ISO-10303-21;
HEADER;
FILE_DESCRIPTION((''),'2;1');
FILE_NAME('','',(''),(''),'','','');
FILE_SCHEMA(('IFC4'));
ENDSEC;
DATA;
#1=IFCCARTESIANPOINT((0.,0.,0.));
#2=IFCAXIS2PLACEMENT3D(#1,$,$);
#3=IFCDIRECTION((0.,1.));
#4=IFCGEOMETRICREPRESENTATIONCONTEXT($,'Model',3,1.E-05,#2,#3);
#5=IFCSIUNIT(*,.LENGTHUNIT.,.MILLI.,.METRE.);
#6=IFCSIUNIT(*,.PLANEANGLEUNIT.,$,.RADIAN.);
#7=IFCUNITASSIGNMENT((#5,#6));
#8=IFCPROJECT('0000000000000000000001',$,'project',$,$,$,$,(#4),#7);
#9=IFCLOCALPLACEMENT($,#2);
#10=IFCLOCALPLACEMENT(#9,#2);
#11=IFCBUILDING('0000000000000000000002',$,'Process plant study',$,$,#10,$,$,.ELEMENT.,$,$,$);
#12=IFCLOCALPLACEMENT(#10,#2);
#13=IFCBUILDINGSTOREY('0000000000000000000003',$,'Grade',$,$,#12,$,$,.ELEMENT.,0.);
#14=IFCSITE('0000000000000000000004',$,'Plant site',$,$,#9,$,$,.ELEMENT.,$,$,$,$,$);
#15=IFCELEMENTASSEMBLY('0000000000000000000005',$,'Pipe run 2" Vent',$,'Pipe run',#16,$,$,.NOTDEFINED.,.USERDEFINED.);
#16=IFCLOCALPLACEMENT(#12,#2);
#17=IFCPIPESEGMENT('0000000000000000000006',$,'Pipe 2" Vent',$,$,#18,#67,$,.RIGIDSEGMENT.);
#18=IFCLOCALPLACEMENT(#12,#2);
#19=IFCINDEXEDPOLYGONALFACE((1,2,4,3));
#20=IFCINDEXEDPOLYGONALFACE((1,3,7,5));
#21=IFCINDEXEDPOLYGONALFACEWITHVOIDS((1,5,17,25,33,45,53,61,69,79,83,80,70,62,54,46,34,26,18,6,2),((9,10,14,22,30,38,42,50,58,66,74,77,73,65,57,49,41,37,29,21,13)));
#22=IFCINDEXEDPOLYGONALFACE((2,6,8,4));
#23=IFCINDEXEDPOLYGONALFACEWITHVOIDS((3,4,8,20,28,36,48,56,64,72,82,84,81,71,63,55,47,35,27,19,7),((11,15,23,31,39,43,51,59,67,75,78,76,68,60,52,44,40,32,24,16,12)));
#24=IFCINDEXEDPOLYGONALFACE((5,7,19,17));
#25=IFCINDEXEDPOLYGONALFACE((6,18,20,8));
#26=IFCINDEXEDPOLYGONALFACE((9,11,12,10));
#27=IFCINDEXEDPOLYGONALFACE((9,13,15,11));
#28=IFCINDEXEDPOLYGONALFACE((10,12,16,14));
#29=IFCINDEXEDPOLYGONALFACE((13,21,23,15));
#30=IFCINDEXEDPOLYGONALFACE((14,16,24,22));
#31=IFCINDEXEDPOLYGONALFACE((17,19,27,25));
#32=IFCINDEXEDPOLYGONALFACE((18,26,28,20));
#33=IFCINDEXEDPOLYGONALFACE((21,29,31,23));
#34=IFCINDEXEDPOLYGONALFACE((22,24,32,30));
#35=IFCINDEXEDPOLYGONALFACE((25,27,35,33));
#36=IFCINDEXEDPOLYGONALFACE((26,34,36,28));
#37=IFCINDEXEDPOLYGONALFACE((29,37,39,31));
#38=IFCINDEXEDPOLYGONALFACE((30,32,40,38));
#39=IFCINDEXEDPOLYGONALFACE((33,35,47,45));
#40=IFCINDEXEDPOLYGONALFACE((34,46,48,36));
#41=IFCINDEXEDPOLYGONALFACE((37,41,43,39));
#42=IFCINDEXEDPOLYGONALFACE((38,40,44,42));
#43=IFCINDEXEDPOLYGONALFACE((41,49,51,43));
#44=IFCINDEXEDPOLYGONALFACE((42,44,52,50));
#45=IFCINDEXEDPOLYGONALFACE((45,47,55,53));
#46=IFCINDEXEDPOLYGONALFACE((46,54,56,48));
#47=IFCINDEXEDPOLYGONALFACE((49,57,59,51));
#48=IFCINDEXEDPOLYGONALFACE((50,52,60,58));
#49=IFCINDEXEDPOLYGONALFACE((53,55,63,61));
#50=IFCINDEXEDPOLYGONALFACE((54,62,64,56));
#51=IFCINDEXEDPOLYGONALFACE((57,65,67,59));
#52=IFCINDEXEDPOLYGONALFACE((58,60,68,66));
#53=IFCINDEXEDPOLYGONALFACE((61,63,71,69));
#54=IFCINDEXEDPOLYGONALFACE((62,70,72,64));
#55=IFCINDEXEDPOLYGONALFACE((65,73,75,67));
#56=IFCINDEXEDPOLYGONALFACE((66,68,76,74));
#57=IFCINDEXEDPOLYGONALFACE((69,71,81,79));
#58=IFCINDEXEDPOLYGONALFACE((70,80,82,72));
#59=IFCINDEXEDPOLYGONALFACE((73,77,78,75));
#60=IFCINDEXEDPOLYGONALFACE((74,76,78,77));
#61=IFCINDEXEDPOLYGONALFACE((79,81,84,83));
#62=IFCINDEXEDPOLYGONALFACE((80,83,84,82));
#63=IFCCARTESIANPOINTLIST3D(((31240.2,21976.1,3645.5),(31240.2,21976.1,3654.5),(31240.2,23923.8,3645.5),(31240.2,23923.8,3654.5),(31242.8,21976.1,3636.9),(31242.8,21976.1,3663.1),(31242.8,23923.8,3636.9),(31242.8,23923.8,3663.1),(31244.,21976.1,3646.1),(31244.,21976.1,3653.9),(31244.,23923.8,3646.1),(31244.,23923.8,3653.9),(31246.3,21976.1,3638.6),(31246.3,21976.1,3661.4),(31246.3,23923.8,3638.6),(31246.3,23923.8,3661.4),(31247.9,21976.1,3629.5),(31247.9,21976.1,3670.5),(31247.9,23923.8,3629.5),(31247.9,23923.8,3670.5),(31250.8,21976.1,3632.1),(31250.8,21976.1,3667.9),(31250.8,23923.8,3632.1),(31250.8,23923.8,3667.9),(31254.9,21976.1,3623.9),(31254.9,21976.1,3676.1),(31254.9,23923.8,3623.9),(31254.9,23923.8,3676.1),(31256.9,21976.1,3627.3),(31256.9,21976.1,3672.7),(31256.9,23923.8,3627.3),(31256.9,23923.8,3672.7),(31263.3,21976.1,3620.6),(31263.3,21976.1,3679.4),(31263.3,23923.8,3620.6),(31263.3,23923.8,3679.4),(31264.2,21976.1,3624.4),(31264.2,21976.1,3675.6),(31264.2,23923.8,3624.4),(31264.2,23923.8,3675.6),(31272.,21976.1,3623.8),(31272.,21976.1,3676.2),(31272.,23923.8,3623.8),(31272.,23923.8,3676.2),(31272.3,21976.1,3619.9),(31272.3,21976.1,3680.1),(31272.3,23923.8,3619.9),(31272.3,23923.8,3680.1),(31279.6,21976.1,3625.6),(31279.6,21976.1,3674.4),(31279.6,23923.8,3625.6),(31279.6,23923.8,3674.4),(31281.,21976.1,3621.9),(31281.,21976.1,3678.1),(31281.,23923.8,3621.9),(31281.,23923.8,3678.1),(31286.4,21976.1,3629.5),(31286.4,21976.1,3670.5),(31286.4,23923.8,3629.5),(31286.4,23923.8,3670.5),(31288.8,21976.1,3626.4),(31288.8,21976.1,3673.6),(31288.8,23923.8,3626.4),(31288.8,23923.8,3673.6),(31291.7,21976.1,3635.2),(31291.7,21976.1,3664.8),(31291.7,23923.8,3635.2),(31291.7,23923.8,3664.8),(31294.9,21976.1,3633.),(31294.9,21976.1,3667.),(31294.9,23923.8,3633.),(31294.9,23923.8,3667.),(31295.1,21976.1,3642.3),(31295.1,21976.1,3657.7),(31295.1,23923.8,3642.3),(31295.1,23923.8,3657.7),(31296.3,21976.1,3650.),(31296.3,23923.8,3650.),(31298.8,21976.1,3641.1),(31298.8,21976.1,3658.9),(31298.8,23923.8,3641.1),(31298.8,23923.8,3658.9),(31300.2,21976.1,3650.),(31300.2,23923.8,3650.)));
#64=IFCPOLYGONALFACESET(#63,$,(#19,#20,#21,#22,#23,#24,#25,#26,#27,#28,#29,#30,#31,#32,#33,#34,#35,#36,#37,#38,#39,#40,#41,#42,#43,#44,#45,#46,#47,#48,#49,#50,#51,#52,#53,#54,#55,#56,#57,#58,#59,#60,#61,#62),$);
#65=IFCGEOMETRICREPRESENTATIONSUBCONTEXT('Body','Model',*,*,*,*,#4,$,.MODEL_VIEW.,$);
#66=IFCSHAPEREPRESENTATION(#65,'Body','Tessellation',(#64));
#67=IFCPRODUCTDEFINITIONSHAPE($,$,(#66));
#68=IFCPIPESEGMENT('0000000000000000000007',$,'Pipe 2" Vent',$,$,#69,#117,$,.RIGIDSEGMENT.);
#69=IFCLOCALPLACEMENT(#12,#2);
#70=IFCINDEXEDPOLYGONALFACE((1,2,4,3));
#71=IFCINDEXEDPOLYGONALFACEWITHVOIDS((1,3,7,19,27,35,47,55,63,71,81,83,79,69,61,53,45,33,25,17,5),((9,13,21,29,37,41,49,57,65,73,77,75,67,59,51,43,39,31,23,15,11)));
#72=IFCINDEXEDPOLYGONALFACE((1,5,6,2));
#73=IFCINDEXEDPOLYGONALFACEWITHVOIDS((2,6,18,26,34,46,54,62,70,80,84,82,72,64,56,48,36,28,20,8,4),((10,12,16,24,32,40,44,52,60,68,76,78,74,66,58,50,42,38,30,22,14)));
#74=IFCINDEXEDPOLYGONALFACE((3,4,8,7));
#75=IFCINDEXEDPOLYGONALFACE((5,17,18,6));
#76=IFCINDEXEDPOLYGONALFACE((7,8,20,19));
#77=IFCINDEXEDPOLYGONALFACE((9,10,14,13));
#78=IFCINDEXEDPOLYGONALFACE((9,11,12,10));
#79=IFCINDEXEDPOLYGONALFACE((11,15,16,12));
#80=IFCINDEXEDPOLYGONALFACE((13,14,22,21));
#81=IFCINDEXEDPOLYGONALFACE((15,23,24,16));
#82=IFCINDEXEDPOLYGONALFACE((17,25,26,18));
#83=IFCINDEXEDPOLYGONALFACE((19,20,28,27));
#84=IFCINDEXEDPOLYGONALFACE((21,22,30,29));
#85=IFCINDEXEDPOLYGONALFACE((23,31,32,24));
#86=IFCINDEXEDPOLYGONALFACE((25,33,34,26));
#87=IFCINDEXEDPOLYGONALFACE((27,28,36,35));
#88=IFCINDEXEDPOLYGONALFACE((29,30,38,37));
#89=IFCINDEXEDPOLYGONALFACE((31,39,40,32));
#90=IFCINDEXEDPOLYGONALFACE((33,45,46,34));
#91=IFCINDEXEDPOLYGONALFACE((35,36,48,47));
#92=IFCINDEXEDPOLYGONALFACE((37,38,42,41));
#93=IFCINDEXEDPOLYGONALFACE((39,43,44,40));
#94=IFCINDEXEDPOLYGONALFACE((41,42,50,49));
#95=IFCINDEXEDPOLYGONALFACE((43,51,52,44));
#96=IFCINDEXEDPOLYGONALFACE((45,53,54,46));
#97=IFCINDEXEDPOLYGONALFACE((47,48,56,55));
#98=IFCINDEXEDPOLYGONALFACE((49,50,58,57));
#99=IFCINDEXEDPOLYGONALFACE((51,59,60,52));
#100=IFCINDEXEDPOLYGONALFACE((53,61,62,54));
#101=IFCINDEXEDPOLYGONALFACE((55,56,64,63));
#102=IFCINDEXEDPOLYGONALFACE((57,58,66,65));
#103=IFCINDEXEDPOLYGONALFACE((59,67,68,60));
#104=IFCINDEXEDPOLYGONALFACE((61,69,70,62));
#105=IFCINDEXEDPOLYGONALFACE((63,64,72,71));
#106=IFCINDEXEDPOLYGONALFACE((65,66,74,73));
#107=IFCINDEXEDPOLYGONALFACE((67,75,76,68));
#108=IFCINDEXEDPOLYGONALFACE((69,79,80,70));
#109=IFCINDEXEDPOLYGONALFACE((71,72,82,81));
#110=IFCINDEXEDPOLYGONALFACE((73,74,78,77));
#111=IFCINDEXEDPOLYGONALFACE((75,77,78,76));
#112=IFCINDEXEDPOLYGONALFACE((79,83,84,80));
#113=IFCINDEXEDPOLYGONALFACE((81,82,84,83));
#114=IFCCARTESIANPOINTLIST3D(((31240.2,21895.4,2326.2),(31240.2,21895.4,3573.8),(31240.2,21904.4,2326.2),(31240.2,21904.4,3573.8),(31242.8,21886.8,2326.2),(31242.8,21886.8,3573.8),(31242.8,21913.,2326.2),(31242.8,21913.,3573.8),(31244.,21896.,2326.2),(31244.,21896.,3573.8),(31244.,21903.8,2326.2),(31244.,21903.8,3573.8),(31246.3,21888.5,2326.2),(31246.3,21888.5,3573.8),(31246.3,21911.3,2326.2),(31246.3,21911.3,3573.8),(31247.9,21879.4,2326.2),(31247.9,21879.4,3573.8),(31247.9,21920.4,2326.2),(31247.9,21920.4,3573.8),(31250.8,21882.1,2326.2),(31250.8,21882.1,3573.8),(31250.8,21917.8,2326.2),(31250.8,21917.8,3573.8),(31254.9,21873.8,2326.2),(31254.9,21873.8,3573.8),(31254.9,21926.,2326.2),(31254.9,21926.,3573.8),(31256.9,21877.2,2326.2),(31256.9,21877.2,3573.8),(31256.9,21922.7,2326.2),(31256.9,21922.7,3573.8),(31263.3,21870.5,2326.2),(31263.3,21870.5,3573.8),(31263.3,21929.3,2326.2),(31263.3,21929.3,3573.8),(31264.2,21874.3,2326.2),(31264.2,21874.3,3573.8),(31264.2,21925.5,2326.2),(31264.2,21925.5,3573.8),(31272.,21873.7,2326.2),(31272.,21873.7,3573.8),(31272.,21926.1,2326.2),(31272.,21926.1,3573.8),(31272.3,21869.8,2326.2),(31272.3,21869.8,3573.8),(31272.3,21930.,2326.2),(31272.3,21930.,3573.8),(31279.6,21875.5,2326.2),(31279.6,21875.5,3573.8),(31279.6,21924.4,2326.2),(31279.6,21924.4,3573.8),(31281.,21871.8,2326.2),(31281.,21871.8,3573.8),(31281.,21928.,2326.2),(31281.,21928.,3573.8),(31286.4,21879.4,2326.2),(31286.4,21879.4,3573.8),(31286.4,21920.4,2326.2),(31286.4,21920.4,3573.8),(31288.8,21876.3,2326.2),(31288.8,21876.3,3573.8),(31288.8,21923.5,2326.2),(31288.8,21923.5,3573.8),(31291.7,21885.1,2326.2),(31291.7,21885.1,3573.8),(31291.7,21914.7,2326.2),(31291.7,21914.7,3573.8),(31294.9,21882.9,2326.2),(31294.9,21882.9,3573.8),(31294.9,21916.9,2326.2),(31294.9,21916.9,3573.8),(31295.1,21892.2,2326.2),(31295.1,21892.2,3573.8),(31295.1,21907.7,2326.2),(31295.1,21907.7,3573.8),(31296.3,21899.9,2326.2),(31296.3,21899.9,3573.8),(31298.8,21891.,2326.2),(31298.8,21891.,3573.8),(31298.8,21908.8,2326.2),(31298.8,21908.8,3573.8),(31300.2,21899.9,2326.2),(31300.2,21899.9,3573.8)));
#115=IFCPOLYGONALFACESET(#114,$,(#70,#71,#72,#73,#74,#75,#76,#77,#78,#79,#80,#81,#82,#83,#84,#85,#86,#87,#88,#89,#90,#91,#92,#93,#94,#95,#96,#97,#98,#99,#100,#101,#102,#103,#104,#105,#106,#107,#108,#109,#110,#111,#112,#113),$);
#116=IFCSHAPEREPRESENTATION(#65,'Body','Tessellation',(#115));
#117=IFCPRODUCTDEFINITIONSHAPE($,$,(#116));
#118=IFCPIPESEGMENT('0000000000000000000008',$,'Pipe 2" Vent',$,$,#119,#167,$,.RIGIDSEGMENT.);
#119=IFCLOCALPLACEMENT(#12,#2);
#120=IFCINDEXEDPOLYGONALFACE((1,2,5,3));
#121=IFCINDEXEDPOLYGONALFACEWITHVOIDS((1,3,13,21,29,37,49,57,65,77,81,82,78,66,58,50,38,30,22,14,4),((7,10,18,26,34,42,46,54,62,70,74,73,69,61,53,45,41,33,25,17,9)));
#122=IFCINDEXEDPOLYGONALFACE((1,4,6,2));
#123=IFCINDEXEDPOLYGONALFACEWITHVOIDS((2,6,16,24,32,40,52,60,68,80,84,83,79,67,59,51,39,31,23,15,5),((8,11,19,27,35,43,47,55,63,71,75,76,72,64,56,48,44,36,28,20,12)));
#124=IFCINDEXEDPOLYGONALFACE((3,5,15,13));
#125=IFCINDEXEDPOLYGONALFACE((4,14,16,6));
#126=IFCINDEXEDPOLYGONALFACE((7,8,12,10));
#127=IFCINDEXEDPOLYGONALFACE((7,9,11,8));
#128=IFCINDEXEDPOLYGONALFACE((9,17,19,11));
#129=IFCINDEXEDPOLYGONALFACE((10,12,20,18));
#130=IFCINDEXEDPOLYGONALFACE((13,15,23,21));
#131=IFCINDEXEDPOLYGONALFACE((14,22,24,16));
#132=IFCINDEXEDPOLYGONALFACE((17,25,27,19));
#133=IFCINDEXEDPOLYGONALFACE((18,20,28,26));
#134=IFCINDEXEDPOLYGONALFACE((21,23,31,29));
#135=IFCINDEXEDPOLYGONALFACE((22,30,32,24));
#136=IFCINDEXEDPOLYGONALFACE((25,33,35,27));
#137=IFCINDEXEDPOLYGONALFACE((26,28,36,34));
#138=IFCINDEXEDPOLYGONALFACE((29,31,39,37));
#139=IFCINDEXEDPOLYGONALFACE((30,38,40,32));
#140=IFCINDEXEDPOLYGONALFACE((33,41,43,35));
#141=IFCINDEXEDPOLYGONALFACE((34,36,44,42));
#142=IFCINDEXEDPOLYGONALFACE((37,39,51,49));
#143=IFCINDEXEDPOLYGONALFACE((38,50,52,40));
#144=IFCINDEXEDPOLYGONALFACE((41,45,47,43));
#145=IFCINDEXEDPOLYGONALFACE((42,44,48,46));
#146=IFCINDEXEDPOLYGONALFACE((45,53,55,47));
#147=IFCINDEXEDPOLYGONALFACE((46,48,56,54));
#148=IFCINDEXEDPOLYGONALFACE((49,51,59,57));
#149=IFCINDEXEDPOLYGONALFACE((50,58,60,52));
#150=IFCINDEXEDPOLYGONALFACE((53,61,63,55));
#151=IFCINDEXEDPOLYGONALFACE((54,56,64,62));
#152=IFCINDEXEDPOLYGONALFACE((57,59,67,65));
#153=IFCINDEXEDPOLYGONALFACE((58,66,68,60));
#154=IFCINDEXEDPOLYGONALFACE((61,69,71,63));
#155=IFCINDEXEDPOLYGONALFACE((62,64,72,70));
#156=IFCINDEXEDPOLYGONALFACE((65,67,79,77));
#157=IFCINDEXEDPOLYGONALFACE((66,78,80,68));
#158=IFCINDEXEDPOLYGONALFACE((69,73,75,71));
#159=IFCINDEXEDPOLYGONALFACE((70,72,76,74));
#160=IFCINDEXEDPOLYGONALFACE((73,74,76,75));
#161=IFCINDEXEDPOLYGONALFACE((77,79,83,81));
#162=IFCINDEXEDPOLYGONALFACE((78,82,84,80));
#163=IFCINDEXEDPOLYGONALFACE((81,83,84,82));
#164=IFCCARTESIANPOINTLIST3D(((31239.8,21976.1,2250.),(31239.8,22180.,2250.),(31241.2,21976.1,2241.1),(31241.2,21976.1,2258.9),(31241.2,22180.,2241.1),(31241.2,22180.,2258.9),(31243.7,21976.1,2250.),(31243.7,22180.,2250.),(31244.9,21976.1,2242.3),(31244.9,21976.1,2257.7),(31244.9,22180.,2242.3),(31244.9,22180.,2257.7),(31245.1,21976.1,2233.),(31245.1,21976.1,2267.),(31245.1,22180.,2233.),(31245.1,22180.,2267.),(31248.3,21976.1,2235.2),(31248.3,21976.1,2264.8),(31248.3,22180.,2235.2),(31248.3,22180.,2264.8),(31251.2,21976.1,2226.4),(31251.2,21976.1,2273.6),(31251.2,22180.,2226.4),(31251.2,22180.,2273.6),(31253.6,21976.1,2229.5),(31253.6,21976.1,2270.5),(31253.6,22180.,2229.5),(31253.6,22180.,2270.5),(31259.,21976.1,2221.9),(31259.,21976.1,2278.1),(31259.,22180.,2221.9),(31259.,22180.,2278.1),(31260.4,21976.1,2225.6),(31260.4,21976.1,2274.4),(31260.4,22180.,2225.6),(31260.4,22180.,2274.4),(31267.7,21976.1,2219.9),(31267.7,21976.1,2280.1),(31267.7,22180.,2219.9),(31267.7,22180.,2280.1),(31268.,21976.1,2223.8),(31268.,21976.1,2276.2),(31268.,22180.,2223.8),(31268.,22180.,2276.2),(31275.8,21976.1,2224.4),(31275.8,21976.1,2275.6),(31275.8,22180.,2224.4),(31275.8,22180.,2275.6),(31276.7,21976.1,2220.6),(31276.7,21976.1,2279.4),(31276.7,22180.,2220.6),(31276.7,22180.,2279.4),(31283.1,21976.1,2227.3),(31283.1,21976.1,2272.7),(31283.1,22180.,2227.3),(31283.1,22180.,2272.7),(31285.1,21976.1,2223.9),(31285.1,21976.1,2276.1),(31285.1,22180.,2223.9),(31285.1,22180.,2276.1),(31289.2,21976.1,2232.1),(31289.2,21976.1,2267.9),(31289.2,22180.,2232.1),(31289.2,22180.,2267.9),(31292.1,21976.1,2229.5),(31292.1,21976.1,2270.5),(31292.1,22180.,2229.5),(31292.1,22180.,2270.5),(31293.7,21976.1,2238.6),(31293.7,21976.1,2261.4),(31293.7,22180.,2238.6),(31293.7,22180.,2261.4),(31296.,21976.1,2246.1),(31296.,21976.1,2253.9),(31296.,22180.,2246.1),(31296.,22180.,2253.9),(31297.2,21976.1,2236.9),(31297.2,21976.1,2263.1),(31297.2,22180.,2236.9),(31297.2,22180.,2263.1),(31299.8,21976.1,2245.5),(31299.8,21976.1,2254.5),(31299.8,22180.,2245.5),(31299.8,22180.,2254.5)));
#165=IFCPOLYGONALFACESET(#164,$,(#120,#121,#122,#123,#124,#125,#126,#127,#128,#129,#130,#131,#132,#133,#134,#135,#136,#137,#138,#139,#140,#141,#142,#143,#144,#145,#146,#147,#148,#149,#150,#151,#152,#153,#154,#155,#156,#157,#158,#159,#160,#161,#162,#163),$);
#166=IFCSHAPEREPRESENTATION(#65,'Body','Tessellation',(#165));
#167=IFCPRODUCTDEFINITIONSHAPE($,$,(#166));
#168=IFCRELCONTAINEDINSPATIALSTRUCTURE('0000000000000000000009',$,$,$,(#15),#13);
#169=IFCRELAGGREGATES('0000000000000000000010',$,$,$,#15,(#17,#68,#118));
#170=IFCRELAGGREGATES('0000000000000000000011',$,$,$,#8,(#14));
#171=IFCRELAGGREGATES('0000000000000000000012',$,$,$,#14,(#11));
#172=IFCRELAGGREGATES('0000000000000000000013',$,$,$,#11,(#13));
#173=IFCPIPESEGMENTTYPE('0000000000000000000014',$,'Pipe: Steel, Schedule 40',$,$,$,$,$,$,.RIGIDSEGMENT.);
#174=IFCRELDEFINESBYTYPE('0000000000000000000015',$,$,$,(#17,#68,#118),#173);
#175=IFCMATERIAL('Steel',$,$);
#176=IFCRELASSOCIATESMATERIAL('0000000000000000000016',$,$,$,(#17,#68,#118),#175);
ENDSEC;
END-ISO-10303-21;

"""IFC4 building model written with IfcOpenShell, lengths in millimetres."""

from ifc_helpers import new_model, si_unit, direction, frame, origin, origin_with_axes, origin_2d, place, context, subcontext, project, spatial, hollow_circle, extrude, material, type_object, element, aggregate, save


model = new_model("IFC4")

# Units and contexts
model_context = context("Model", 3, precision=1e-05, world=origin(), true_north=direction((0.0, 1.0)))
body_context = subcontext(model_context, "Body", "Model", "MODEL_VIEW")
ifc_project = project(units=[si_unit("LENGTHUNIT", "METRE", prefix="MILLI"), si_unit("PLANEANGLEUNIT", "RADIAN")], contexts=[model_context])

# Site, building, storey
site_placement = place(None, origin())
site = spatial("IfcSite", under=ifc_project, at=site_placement, Name="Plant site", CompositionType="ELEMENT")
building_placement = place(site_placement, origin())
building = spatial("IfcBuilding", under=site, at=building_placement, Name="Process plant study", CompositionType="ELEMENT")
storey_placement = place(building_placement, origin())
storey = spatial("IfcBuildingStorey", under=building, at=storey_placement, Name="Grade", CompositionType="ELEMENT", Elevation=0.0)

# Shared definitions
ifc_material = material(Name="Steel")
pipe_segment_type = type_object("IfcPipeSegmentType", Name="Pipe: Steel, Schedule 40", PredefinedType="RIGIDSEGMENT")

# Element assembly, pipe segments
assembly_1_placement = place(storey_placement, origin_with_axes())
assembly_1 = element("IfcElementAssembly", 1, at=assembly_1_placement, inside=storey, Name="Pipe run 2\" Vent", ObjectType="Pipe run", AssemblyPlace="NOTDEFINED", PredefinedType="USERDEFINED")
pipe_segment_1_placement = place(storey_placement, origin_with_axes())
pipe_segment_1 = element("IfcPipeSegment", 2, at=pipe_segment_1_placement, type_object=pipe_segment_type, material=ifc_material, Name="Pipe 2\" Vent", PredefinedType="RIGIDSEGMENT", context=body_context, shape_type="SweptSolid", body=[
    extrude(hollow_circle(Radius=30.2, WallThickness=3.9, at=origin_2d()), frame((31270.0, 23923.8, 3650.0), z_axis=(0.0, -1.0, 0.0), x_axis=(1.0, 0.0, 0.0)), (0.0, 0.0, 1.0), 1947.7),
])
pipe_segment_2_placement = place(storey_placement, origin_with_axes())
pipe_segment_2 = element("IfcPipeSegment", 3, at=pipe_segment_2_placement, type_object=pipe_segment_type, material=ifc_material, Name="Pipe 2\" Vent", PredefinedType="RIGIDSEGMENT", context=body_context, shape_type="SweptSolid", body=[
    extrude(hollow_circle(Radius=30.2, WallThickness=3.9, at=origin_2d()), frame((31270.0, 21899.9, 3573.8), z_axis=(0.0, 0.0, -1.0), x_axis=(1.0, 0.0, 0.0)), (0.0, 0.0, 1.0), 1247.6),
])
pipe_segment_3_placement = place(storey_placement, origin_with_axes())
pipe_segment_3 = element("IfcPipeSegment", 4, at=pipe_segment_3_placement, type_object=pipe_segment_type, material=ifc_material, Name="Pipe 2\" Vent", PredefinedType="RIGIDSEGMENT", context=body_context, shape_type="SweptSolid", body=[
    extrude(hollow_circle(Radius=30.2, WallThickness=3.9, at=origin_2d()), frame((31270.0, 21976.1, 2250.0), z_axis=(0.0, 1.0, 0.0), x_axis=(-1.0, 0.0, 0.0)), (0.0, 0.0, 1.0), 203.9),
])

aggregate(assembly_1, [pipe_segment_1, pipe_segment_2, pipe_segment_3])

save(model, "model.ifc")
